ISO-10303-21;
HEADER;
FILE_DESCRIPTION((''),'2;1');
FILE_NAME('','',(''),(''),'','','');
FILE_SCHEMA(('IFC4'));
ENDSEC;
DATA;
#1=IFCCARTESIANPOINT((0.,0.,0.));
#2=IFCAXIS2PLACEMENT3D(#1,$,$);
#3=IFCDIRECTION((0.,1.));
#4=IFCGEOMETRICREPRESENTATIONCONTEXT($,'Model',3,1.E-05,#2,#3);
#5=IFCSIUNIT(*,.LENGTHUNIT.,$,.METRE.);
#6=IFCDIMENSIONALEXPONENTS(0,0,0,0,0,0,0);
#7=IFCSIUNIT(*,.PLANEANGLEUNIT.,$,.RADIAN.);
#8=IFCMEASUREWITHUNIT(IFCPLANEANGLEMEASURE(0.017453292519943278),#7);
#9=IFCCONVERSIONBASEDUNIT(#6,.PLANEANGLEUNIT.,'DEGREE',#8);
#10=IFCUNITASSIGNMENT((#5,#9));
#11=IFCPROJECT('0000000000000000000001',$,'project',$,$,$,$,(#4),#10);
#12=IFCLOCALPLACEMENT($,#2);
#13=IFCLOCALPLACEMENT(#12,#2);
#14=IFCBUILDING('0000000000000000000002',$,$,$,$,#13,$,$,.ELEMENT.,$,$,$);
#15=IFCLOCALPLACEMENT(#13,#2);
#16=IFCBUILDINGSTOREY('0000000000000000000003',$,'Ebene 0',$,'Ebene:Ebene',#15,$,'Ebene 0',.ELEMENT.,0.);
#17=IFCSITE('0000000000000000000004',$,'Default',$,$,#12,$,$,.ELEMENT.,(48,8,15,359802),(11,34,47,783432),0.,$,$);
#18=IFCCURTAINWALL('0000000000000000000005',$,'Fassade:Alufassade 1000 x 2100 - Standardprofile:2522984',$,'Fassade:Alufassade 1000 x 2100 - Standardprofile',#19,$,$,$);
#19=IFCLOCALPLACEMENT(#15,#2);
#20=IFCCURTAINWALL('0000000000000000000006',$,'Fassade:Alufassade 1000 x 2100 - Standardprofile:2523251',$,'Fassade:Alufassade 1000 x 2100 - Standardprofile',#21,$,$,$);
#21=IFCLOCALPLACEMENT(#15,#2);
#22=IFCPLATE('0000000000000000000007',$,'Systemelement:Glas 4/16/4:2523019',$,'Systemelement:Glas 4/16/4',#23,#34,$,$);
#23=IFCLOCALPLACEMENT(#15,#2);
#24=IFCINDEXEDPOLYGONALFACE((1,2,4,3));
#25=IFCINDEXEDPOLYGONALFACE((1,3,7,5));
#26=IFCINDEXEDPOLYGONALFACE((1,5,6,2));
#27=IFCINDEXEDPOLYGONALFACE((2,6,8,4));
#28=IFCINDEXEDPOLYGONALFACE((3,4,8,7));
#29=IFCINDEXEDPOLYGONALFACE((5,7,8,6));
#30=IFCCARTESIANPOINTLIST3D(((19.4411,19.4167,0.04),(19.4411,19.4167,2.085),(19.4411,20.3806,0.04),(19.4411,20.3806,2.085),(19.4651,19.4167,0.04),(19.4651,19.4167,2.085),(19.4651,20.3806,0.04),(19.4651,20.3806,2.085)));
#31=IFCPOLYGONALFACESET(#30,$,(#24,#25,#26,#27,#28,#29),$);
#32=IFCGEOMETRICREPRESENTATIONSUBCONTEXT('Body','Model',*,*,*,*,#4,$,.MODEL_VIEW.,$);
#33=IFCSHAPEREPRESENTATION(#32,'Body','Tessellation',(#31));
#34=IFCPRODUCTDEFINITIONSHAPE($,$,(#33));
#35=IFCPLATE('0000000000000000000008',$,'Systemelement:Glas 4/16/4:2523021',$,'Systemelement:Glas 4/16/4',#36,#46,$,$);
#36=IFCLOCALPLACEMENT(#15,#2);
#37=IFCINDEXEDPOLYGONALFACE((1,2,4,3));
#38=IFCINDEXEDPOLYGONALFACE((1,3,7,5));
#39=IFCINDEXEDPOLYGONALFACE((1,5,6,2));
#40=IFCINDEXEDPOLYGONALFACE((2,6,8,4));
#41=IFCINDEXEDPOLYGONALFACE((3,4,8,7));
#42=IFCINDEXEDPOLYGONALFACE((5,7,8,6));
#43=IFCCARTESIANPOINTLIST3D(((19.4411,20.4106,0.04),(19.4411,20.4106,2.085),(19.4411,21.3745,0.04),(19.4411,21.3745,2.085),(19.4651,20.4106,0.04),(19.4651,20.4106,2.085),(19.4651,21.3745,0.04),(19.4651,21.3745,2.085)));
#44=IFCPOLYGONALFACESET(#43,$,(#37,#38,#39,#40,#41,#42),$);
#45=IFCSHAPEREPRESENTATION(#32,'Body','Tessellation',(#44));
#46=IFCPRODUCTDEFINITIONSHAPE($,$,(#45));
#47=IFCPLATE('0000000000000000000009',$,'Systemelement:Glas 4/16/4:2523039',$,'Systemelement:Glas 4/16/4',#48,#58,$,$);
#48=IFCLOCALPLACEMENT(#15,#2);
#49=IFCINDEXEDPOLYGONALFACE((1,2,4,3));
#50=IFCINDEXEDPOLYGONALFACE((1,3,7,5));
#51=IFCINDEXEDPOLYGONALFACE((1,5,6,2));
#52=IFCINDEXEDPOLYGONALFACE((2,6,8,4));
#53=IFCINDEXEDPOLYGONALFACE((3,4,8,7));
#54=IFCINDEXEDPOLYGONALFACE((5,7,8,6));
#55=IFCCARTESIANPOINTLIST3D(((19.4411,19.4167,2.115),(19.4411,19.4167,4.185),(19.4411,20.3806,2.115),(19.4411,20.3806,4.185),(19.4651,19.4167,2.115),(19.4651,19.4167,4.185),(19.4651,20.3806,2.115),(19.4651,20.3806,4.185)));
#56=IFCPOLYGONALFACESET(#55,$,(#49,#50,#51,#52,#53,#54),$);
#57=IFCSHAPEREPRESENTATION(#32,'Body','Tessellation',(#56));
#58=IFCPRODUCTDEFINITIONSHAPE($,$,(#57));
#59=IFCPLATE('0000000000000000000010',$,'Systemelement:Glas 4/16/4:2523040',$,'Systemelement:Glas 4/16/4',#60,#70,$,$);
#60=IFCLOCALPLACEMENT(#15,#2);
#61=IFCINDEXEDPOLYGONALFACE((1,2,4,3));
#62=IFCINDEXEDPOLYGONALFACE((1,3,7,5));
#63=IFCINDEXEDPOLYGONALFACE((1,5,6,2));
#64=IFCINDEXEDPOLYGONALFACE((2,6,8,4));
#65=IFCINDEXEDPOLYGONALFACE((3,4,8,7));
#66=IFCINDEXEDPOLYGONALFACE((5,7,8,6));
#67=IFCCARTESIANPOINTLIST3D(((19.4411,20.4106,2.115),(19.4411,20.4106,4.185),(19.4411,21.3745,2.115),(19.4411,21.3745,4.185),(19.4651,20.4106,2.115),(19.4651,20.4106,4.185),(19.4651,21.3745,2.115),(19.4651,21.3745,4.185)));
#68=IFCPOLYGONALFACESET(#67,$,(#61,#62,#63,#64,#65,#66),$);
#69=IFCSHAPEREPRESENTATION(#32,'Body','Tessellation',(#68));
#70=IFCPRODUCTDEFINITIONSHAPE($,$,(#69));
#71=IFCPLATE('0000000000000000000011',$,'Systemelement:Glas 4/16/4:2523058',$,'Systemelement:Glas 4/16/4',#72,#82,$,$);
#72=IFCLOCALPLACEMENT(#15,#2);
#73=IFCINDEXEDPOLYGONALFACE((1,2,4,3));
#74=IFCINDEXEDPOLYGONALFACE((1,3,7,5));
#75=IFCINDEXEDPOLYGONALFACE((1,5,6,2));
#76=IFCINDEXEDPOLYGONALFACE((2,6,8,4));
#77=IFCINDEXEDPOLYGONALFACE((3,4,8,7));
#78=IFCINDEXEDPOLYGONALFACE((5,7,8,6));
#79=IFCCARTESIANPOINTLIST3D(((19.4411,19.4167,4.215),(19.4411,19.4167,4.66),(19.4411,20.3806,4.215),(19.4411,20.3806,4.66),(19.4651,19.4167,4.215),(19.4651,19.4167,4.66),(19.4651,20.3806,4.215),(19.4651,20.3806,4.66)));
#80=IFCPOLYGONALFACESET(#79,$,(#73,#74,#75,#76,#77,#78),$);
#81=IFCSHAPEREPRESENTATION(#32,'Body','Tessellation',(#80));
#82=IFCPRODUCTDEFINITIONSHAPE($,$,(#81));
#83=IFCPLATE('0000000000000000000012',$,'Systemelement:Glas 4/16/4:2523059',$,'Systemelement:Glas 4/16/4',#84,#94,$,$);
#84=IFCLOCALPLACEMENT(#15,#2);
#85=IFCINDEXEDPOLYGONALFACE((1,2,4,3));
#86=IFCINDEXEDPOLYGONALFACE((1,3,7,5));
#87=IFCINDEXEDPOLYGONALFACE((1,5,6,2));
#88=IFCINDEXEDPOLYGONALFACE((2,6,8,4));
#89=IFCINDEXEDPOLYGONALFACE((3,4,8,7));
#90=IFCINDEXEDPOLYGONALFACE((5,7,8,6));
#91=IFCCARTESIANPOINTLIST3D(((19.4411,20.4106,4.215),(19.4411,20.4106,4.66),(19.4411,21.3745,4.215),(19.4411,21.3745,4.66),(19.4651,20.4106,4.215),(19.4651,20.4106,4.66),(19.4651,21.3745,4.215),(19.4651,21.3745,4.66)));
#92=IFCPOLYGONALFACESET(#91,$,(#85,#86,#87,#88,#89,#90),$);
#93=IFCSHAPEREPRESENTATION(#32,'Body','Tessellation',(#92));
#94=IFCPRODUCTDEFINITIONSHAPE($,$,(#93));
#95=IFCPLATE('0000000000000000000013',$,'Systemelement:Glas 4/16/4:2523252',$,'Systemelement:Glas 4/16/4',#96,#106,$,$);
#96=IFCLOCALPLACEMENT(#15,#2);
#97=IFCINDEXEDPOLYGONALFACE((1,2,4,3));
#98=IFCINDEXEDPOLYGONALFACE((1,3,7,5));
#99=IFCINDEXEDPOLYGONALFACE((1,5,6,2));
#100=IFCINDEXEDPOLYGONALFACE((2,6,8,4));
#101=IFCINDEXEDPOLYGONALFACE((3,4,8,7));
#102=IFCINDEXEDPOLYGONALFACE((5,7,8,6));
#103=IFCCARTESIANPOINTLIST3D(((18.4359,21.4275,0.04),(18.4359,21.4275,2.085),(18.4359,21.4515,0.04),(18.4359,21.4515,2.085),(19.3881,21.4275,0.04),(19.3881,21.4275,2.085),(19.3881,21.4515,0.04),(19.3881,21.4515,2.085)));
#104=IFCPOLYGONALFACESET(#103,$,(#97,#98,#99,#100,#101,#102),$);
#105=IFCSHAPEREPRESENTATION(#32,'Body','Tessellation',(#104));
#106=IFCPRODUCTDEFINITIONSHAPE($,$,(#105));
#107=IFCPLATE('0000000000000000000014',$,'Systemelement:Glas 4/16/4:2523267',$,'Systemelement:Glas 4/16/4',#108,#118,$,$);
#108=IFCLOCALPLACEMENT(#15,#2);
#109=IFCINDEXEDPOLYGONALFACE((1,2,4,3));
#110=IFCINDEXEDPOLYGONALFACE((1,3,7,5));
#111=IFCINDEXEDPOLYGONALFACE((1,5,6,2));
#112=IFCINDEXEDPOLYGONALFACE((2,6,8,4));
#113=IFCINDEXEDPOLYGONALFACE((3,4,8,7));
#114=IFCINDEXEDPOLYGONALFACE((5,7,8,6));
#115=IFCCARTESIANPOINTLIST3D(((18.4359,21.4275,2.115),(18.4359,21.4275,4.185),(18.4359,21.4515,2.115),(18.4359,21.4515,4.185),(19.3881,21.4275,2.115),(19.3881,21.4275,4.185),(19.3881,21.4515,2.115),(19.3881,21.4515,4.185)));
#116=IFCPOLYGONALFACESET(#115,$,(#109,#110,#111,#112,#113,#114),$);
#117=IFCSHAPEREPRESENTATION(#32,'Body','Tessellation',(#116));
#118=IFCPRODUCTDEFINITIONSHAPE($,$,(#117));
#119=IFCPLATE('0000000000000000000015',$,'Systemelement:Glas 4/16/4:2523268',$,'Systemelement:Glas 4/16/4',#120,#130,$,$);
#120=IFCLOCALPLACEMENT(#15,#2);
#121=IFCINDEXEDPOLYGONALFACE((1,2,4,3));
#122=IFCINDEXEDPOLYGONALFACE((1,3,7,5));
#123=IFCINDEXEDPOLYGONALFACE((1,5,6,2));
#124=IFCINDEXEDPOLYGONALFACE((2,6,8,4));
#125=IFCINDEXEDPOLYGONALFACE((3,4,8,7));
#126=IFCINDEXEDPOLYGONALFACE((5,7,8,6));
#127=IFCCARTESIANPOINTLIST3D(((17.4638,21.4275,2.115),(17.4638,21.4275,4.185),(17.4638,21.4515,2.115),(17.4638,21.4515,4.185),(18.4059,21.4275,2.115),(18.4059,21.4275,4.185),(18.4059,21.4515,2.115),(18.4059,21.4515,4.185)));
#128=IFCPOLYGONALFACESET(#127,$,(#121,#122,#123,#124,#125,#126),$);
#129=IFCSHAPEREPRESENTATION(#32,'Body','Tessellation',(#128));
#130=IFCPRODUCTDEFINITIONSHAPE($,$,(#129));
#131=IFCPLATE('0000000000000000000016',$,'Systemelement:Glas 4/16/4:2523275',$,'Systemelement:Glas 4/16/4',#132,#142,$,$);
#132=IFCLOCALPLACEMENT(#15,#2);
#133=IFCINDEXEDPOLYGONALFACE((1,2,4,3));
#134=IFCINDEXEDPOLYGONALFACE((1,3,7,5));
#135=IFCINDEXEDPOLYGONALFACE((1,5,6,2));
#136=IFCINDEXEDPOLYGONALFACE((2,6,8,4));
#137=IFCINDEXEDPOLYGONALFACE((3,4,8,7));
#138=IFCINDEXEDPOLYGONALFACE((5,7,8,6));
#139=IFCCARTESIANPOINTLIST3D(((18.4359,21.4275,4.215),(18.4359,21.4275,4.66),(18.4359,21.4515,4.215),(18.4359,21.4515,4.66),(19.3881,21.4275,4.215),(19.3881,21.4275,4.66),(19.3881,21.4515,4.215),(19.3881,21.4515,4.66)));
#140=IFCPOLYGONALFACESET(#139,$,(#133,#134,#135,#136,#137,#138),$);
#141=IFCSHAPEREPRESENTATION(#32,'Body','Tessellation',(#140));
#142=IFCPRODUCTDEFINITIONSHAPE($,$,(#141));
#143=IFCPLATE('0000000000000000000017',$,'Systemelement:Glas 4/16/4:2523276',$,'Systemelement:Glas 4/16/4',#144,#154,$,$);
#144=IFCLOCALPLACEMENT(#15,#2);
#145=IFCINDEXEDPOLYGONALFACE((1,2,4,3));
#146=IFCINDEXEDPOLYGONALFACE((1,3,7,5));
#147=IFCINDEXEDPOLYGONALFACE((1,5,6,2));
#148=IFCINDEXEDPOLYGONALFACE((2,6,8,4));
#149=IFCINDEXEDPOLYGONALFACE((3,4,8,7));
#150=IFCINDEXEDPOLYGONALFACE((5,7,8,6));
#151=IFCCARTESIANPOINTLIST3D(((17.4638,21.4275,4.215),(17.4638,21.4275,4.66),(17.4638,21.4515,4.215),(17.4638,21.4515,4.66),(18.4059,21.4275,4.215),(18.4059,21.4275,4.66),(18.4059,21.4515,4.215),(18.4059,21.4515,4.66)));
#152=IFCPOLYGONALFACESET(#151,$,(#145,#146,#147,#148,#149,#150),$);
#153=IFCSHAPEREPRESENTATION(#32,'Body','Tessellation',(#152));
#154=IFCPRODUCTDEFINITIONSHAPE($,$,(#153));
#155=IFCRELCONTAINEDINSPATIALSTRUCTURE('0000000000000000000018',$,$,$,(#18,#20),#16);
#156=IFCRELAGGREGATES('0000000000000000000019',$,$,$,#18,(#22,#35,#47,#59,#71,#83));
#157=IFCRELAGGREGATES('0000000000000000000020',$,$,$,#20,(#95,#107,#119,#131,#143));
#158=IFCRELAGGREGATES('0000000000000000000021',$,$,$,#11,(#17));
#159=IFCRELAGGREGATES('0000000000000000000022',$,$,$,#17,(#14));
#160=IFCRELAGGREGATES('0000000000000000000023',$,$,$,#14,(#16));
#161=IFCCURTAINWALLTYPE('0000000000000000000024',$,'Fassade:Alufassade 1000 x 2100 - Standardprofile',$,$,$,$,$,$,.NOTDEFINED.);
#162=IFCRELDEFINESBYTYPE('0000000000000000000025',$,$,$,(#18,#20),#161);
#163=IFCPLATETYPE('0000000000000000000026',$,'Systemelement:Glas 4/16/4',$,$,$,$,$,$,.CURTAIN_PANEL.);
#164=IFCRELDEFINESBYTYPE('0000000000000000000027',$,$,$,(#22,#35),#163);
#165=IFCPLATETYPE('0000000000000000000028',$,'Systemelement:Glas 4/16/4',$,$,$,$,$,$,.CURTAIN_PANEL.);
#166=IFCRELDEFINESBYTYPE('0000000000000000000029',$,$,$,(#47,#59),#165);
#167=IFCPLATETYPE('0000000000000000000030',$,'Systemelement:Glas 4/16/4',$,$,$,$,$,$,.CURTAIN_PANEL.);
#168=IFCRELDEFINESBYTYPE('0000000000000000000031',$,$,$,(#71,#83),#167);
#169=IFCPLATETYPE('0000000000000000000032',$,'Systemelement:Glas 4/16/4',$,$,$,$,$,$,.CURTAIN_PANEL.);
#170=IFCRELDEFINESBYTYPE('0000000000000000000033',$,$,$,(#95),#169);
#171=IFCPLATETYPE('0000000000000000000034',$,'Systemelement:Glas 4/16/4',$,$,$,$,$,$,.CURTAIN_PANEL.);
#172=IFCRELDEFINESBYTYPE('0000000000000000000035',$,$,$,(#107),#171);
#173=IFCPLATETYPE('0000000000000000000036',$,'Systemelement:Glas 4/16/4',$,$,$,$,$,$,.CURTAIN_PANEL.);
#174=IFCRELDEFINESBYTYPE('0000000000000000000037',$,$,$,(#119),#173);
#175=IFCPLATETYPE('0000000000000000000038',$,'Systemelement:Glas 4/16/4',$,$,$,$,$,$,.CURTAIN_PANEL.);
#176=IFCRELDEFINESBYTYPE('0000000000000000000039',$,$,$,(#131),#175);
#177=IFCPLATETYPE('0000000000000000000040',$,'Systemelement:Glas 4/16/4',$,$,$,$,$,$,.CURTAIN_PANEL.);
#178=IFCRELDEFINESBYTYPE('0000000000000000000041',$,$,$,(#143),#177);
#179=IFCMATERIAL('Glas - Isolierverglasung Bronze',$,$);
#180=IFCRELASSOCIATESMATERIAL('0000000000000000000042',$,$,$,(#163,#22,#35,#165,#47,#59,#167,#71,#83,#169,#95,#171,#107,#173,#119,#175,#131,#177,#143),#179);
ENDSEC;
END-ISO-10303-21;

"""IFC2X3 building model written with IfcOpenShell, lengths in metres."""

from ifc_helpers import new_model, entity, si_unit, converted_unit, direction, frame, origin, origin_2d_with_axis, place, context, subcontext, project, spatial, rectangle, extrude, source, transform, mapped, material, type_object, type_shapes, element, aggregate, save


model = new_model("IFC2X3")

# Units and contexts
model_context = context("Model", 3, precision=1e-05, world=origin(), true_north=direction((0.0, 1.0)))
body_context = subcontext(model_context, "Body", "Model", "MODEL_VIEW")
ifc_project = project(units=[si_unit("LENGTHUNIT", "METRE"), converted_unit("PLANEANGLEUNIT", "DEGREE", entity("IfcPlaneAngleMeasure", 0.017453292519943278), si_unit("PLANEANGLEUNIT", "RADIAN"), dimensions=[0, 0, 0, 0, 0, 0, 0])], contexts=[model_context])

# Site, building, storey
site_placement = place(None, origin())
site = spatial("IfcSite", under=ifc_project, at=site_placement, Name="Default", CompositionType="ELEMENT", RefLatitude=(48, 8, 15, 359802), RefLongitude=(11, 34, 47, 783432), RefElevation=0.0)
building_placement = place(site_placement, origin())
building = spatial("IfcBuilding", under=site, at=building_placement, CompositionType="ELEMENT")
storey_placement = place(building_placement, origin())
storey = spatial("IfcBuildingStorey", under=building, at=storey_placement, Name="Ebene 0", ObjectType="Ebene:Ebene", LongName="Ebene 0", CompositionType="ELEMENT", Elevation=0.0)

# Curtain walls
curtain_wall_type = type_object("IfcCurtainWallType", Name="Fassade:Alufassade 1000 x 2100 - Standardprofile", PredefinedType="NOTDEFINED")
curtain_wall_1_placement = place(storey_placement, origin())
curtain_wall_1 = element("IfcCurtainWall", 1, at=curtain_wall_1_placement, inside=storey, type_object=curtain_wall_type, Name="Fassade:Alufassade 1000 x 2100 - Standardprofile:2522984", ObjectType="Fassade:Alufassade 1000 x 2100 - Standardprofile")
curtain_wall_2_placement = place(storey_placement, origin())
curtain_wall_2 = element("IfcCurtainWall", 2, at=curtain_wall_2_placement, inside=storey, type_object=curtain_wall_type, Name="Fassade:Alufassade 1000 x 2100 - Standardprofile:2523251", ObjectType="Fassade:Alufassade 1000 x 2100 - Standardprofile")

# Plates
ifc_material_1 = material(Name="Glas - Isolierverglasung Bronze")
plate_type_1 = type_object("IfcPlateType", Name="Systemelement:Glas 4/16/4", PredefinedType="CURTAIN_PANEL", material=ifc_material_1)
shared_shape_1 = source(origin(), body_context, "Body", "SweptSolid", [
    extrude(rectangle(XDim=0.024, YDim=0.9639, at=origin_2d_with_axis()), frame((0.0, 0.0, 0.0), z_axis=(0.0, 0.0, 1.0), x_axis=(0.0, 1.0, 0.0)), (0.0, 0.0, 1.0), 2.045),
])
type_shapes(plate_type_1, [shared_shape_1])
plate_1_placement = place(curtain_wall_1_placement, frame((19.4531, 19.8987, 0.04), z_axis=(0.0, 0.0, 1.0), x_axis=(0.0, 1.0, 0.0)))
plate_1 = element("IfcPlate", 3, at=plate_1_placement, type_object=plate_type_1, material=ifc_material_1, Name="Systemelement:Glas 4/16/4:2523019", ObjectType="Systemelement:Glas 4/16/4", context=body_context, shape_type="MappedRepresentation", body=[
    mapped(shared_shape_1, transform((0.0, 0.0, 0.0), scale=1.0)),
])
plate_2_placement = place(curtain_wall_1_placement, frame((19.4531, 20.8926, 0.04), z_axis=(0.0, 0.0, 1.0), x_axis=(0.0, 1.0, 0.0)))
plate_2 = element("IfcPlate", 4, at=plate_2_placement, type_object=plate_type_1, material=ifc_material_1, Name="Systemelement:Glas 4/16/4:2523021", ObjectType="Systemelement:Glas 4/16/4", context=body_context, shape_type="MappedRepresentation", body=[
    mapped(shared_shape_1, transform((0.0, 0.0, 0.0), scale=1.0)),
])
plate_type_2 = type_object("IfcPlateType", Name="Systemelement:Glas 4/16/4", PredefinedType="CURTAIN_PANEL", material=ifc_material_1)
shared_shape_2 = source(origin(), body_context, "Body", "SweptSolid", [
    extrude(rectangle(XDim=0.024, YDim=0.9639, at=origin_2d_with_axis()), frame((0.0, 0.0, 0.0), z_axis=(0.0, 0.0, 1.0), x_axis=(0.0, 1.0, 0.0)), (0.0, 0.0, 1.0), 2.07),
])
type_shapes(plate_type_2, [shared_shape_2])
plate_3_placement = place(curtain_wall_1_placement, frame((19.4531, 19.8987, 2.115), z_axis=(0.0, 0.0, 1.0), x_axis=(0.0, 1.0, 0.0)))
plate_3 = element("IfcPlate", 5, at=plate_3_placement, type_object=plate_type_2, material=ifc_material_1, Name="Systemelement:Glas 4/16/4:2523039", ObjectType="Systemelement:Glas 4/16/4", context=body_context, shape_type="MappedRepresentation", body=[
    mapped(shared_shape_2, transform((0.0, 0.0, 0.0), scale=1.0)),
])
plate_4_placement = place(curtain_wall_1_placement, frame((19.4531, 20.8926, 2.115), z_axis=(0.0, 0.0, 1.0), x_axis=(0.0, 1.0, 0.0)))
plate_4 = element("IfcPlate", 6, at=plate_4_placement, type_object=plate_type_2, material=ifc_material_1, Name="Systemelement:Glas 4/16/4:2523040", ObjectType="Systemelement:Glas 4/16/4", context=body_context, shape_type="MappedRepresentation", body=[
    mapped(shared_shape_2, transform((0.0, 0.0, 0.0), scale=1.0)),
])
plate_type_3 = type_object("IfcPlateType", Name="Systemelement:Glas 4/16/4", PredefinedType="CURTAIN_PANEL", material=ifc_material_1)
shared_shape_3 = source(origin(), body_context, "Body", "SweptSolid", [
    extrude(rectangle(XDim=0.024, YDim=0.9639, at=origin_2d_with_axis()), frame((0.0, 0.0, 0.0), z_axis=(0.0, 0.0, 1.0), x_axis=(0.0, 1.0, 0.0)), (0.0, 0.0, 1.0), 0.445),
])
type_shapes(plate_type_3, [shared_shape_3])
plate_5_placement = place(curtain_wall_1_placement, frame((19.4531, 19.8987, 4.215), z_axis=(0.0, 0.0, 1.0), x_axis=(0.0, 1.0, 0.0)))
plate_5 = element("IfcPlate", 7, at=plate_5_placement, type_object=plate_type_3, material=ifc_material_1, Name="Systemelement:Glas 4/16/4:2523058", ObjectType="Systemelement:Glas 4/16/4", context=body_context, shape_type="MappedRepresentation", body=[
    mapped(shared_shape_3, transform((0.0, 0.0, 0.0), scale=1.0)),
])
plate_6_placement = place(curtain_wall_1_placement, frame((19.4531, 20.8926, 4.215), z_axis=(0.0, 0.0, 1.0), x_axis=(0.0, 1.0, 0.0)))
plate_6 = element("IfcPlate", 8, at=plate_6_placement, type_object=plate_type_3, material=ifc_material_1, Name="Systemelement:Glas 4/16/4:2523059", ObjectType="Systemelement:Glas 4/16/4", context=body_context, shape_type="MappedRepresentation", body=[
    mapped(shared_shape_3, transform((0.0, 0.0, 0.0), scale=1.0)),
])
aggregate(curtain_wall_1, [plate_1, plate_2, plate_3, plate_4, plate_5, plate_6])
plate_type_4 = type_object("IfcPlateType", Name="Systemelement:Glas 4/16/4", PredefinedType="CURTAIN_PANEL", material=ifc_material_1)
shared_shape_4 = source(origin(), body_context, "Body", "SweptSolid", [
    extrude(rectangle(XDim=0.024, YDim=0.9521, at=origin_2d_with_axis()), frame((0.0, 0.0, 0.0), z_axis=(0.0, 0.0, 1.0), x_axis=(0.0, 1.0, 0.0)), (0.0, 0.0, 1.0), 2.045),
])
type_shapes(plate_type_4, [shared_shape_4])
plate_7_placement = place(curtain_wall_2_placement, frame((18.912, 21.4395, 0.04), z_axis=(0.0, 0.0, 1.0), x_axis=(-1.0, 0.0, 0.0)))
plate_7 = element("IfcPlate", 9, at=plate_7_placement, type_object=plate_type_4, material=ifc_material_1, Name="Systemelement:Glas 4/16/4:2523252", ObjectType="Systemelement:Glas 4/16/4", context=body_context, shape_type="MappedRepresentation", body=[
    mapped(shared_shape_4, transform((0.0, 0.0, 0.0), scale=1.0)),
])
plate_type_5 = type_object("IfcPlateType", Name="Systemelement:Glas 4/16/4", PredefinedType="CURTAIN_PANEL", material=ifc_material_1)
shared_shape_5 = source(origin(), body_context, "Body", "SweptSolid", [
    extrude(rectangle(XDim=0.024, YDim=0.9521, at=origin_2d_with_axis()), frame((0.0, 0.0, 0.0), z_axis=(0.0, 0.0, 1.0), x_axis=(0.0, 1.0, 0.0)), (0.0, 0.0, 1.0), 2.07),
])
type_shapes(plate_type_5, [shared_shape_5])
plate_8_placement = place(curtain_wall_2_placement, frame((18.912, 21.4395, 2.115), z_axis=(0.0, 0.0, 1.0), x_axis=(-1.0, 0.0, 0.0)))
plate_8 = element("IfcPlate", 10, at=plate_8_placement, type_object=plate_type_5, material=ifc_material_1, Name="Systemelement:Glas 4/16/4:2523267", ObjectType="Systemelement:Glas 4/16/4", context=body_context, shape_type="MappedRepresentation", body=[
    mapped(shared_shape_5, transform((0.0, 0.0, 0.0), scale=1.0)),
])
plate_type_6 = type_object("IfcPlateType", Name="Systemelement:Glas 4/16/4", PredefinedType="CURTAIN_PANEL", material=ifc_material_1)
shared_shape_6 = source(origin(), body_context, "Body", "SweptSolid", [
    extrude(rectangle(XDim=0.024, YDim=0.9421, at=origin_2d_with_axis()), frame((0.0, 0.0, 0.0), z_axis=(0.0, 0.0, 1.0), x_axis=(0.0, 1.0, 0.0)), (0.0, 0.0, 1.0), 2.07),
])
type_shapes(plate_type_6, [shared_shape_6])
plate_9_placement = place(curtain_wall_2_placement, frame((17.9349, 21.4395, 2.115), z_axis=(0.0, 0.0, 1.0), x_axis=(-1.0, 0.0, 0.0)))
plate_9 = element("IfcPlate", 11, at=plate_9_placement, type_object=plate_type_6, material=ifc_material_1, Name="Systemelement:Glas 4/16/4:2523268", ObjectType="Systemelement:Glas 4/16/4", context=body_context, shape_type="MappedRepresentation", body=[
    mapped(shared_shape_6, transform((0.0, 0.0, 0.0), scale=1.0)),
])
plate_type_7 = type_object("IfcPlateType", Name="Systemelement:Glas 4/16/4", PredefinedType="CURTAIN_PANEL", material=ifc_material_1)
shared_shape_7 = source(origin(), body_context, "Body", "SweptSolid", [
    extrude(rectangle(XDim=0.024, YDim=0.9521, at=origin_2d_with_axis()), frame((0.0, 0.0, 0.0), z_axis=(0.0, 0.0, 1.0), x_axis=(0.0, 1.0, 0.0)), (0.0, 0.0, 1.0), 0.445),
])
type_shapes(plate_type_7, [shared_shape_7])
plate_10_placement = place(curtain_wall_2_placement, frame((18.912, 21.4395, 4.215), z_axis=(0.0, 0.0, 1.0), x_axis=(-1.0, 0.0, 0.0)))
plate_10 = element("IfcPlate", 12, at=plate_10_placement, type_object=plate_type_7, material=ifc_material_1, Name="Systemelement:Glas 4/16/4:2523275", ObjectType="Systemelement:Glas 4/16/4", context=body_context, shape_type="MappedRepresentation", body=[
    mapped(shared_shape_7, transform((0.0, 0.0, 0.0), scale=1.0)),
])
plate_type_8 = type_object("IfcPlateType", Name="Systemelement:Glas 4/16/4", PredefinedType="CURTAIN_PANEL", material=ifc_material_1)
shared_shape_8 = source(origin(), body_context, "Body", "SweptSolid", [
    extrude(rectangle(XDim=0.024, YDim=0.9421, at=origin_2d_with_axis()), frame((0.0, 0.0, 0.0), z_axis=(0.0, 0.0, 1.0), x_axis=(0.0, 1.0, 0.0)), (0.0, 0.0, 1.0), 0.445),
])
type_shapes(plate_type_8, [shared_shape_8])
plate_11_placement = place(curtain_wall_2_placement, frame((17.9349, 21.4395, 4.215), z_axis=(0.0, 0.0, 1.0), x_axis=(-1.0, 0.0, 0.0)))
plate_11 = element("IfcPlate", 13, at=plate_11_placement, type_object=plate_type_8, material=ifc_material_1, Name="Systemelement:Glas 4/16/4:2523276", ObjectType="Systemelement:Glas 4/16/4", context=body_context, shape_type="MappedRepresentation", body=[
    mapped(shared_shape_8, transform((0.0, 0.0, 0.0), scale=1.0)),
])
aggregate(curtain_wall_2, [plate_7, plate_8, plate_9, plate_10, plate_11])

save(model, "model.ifc")
